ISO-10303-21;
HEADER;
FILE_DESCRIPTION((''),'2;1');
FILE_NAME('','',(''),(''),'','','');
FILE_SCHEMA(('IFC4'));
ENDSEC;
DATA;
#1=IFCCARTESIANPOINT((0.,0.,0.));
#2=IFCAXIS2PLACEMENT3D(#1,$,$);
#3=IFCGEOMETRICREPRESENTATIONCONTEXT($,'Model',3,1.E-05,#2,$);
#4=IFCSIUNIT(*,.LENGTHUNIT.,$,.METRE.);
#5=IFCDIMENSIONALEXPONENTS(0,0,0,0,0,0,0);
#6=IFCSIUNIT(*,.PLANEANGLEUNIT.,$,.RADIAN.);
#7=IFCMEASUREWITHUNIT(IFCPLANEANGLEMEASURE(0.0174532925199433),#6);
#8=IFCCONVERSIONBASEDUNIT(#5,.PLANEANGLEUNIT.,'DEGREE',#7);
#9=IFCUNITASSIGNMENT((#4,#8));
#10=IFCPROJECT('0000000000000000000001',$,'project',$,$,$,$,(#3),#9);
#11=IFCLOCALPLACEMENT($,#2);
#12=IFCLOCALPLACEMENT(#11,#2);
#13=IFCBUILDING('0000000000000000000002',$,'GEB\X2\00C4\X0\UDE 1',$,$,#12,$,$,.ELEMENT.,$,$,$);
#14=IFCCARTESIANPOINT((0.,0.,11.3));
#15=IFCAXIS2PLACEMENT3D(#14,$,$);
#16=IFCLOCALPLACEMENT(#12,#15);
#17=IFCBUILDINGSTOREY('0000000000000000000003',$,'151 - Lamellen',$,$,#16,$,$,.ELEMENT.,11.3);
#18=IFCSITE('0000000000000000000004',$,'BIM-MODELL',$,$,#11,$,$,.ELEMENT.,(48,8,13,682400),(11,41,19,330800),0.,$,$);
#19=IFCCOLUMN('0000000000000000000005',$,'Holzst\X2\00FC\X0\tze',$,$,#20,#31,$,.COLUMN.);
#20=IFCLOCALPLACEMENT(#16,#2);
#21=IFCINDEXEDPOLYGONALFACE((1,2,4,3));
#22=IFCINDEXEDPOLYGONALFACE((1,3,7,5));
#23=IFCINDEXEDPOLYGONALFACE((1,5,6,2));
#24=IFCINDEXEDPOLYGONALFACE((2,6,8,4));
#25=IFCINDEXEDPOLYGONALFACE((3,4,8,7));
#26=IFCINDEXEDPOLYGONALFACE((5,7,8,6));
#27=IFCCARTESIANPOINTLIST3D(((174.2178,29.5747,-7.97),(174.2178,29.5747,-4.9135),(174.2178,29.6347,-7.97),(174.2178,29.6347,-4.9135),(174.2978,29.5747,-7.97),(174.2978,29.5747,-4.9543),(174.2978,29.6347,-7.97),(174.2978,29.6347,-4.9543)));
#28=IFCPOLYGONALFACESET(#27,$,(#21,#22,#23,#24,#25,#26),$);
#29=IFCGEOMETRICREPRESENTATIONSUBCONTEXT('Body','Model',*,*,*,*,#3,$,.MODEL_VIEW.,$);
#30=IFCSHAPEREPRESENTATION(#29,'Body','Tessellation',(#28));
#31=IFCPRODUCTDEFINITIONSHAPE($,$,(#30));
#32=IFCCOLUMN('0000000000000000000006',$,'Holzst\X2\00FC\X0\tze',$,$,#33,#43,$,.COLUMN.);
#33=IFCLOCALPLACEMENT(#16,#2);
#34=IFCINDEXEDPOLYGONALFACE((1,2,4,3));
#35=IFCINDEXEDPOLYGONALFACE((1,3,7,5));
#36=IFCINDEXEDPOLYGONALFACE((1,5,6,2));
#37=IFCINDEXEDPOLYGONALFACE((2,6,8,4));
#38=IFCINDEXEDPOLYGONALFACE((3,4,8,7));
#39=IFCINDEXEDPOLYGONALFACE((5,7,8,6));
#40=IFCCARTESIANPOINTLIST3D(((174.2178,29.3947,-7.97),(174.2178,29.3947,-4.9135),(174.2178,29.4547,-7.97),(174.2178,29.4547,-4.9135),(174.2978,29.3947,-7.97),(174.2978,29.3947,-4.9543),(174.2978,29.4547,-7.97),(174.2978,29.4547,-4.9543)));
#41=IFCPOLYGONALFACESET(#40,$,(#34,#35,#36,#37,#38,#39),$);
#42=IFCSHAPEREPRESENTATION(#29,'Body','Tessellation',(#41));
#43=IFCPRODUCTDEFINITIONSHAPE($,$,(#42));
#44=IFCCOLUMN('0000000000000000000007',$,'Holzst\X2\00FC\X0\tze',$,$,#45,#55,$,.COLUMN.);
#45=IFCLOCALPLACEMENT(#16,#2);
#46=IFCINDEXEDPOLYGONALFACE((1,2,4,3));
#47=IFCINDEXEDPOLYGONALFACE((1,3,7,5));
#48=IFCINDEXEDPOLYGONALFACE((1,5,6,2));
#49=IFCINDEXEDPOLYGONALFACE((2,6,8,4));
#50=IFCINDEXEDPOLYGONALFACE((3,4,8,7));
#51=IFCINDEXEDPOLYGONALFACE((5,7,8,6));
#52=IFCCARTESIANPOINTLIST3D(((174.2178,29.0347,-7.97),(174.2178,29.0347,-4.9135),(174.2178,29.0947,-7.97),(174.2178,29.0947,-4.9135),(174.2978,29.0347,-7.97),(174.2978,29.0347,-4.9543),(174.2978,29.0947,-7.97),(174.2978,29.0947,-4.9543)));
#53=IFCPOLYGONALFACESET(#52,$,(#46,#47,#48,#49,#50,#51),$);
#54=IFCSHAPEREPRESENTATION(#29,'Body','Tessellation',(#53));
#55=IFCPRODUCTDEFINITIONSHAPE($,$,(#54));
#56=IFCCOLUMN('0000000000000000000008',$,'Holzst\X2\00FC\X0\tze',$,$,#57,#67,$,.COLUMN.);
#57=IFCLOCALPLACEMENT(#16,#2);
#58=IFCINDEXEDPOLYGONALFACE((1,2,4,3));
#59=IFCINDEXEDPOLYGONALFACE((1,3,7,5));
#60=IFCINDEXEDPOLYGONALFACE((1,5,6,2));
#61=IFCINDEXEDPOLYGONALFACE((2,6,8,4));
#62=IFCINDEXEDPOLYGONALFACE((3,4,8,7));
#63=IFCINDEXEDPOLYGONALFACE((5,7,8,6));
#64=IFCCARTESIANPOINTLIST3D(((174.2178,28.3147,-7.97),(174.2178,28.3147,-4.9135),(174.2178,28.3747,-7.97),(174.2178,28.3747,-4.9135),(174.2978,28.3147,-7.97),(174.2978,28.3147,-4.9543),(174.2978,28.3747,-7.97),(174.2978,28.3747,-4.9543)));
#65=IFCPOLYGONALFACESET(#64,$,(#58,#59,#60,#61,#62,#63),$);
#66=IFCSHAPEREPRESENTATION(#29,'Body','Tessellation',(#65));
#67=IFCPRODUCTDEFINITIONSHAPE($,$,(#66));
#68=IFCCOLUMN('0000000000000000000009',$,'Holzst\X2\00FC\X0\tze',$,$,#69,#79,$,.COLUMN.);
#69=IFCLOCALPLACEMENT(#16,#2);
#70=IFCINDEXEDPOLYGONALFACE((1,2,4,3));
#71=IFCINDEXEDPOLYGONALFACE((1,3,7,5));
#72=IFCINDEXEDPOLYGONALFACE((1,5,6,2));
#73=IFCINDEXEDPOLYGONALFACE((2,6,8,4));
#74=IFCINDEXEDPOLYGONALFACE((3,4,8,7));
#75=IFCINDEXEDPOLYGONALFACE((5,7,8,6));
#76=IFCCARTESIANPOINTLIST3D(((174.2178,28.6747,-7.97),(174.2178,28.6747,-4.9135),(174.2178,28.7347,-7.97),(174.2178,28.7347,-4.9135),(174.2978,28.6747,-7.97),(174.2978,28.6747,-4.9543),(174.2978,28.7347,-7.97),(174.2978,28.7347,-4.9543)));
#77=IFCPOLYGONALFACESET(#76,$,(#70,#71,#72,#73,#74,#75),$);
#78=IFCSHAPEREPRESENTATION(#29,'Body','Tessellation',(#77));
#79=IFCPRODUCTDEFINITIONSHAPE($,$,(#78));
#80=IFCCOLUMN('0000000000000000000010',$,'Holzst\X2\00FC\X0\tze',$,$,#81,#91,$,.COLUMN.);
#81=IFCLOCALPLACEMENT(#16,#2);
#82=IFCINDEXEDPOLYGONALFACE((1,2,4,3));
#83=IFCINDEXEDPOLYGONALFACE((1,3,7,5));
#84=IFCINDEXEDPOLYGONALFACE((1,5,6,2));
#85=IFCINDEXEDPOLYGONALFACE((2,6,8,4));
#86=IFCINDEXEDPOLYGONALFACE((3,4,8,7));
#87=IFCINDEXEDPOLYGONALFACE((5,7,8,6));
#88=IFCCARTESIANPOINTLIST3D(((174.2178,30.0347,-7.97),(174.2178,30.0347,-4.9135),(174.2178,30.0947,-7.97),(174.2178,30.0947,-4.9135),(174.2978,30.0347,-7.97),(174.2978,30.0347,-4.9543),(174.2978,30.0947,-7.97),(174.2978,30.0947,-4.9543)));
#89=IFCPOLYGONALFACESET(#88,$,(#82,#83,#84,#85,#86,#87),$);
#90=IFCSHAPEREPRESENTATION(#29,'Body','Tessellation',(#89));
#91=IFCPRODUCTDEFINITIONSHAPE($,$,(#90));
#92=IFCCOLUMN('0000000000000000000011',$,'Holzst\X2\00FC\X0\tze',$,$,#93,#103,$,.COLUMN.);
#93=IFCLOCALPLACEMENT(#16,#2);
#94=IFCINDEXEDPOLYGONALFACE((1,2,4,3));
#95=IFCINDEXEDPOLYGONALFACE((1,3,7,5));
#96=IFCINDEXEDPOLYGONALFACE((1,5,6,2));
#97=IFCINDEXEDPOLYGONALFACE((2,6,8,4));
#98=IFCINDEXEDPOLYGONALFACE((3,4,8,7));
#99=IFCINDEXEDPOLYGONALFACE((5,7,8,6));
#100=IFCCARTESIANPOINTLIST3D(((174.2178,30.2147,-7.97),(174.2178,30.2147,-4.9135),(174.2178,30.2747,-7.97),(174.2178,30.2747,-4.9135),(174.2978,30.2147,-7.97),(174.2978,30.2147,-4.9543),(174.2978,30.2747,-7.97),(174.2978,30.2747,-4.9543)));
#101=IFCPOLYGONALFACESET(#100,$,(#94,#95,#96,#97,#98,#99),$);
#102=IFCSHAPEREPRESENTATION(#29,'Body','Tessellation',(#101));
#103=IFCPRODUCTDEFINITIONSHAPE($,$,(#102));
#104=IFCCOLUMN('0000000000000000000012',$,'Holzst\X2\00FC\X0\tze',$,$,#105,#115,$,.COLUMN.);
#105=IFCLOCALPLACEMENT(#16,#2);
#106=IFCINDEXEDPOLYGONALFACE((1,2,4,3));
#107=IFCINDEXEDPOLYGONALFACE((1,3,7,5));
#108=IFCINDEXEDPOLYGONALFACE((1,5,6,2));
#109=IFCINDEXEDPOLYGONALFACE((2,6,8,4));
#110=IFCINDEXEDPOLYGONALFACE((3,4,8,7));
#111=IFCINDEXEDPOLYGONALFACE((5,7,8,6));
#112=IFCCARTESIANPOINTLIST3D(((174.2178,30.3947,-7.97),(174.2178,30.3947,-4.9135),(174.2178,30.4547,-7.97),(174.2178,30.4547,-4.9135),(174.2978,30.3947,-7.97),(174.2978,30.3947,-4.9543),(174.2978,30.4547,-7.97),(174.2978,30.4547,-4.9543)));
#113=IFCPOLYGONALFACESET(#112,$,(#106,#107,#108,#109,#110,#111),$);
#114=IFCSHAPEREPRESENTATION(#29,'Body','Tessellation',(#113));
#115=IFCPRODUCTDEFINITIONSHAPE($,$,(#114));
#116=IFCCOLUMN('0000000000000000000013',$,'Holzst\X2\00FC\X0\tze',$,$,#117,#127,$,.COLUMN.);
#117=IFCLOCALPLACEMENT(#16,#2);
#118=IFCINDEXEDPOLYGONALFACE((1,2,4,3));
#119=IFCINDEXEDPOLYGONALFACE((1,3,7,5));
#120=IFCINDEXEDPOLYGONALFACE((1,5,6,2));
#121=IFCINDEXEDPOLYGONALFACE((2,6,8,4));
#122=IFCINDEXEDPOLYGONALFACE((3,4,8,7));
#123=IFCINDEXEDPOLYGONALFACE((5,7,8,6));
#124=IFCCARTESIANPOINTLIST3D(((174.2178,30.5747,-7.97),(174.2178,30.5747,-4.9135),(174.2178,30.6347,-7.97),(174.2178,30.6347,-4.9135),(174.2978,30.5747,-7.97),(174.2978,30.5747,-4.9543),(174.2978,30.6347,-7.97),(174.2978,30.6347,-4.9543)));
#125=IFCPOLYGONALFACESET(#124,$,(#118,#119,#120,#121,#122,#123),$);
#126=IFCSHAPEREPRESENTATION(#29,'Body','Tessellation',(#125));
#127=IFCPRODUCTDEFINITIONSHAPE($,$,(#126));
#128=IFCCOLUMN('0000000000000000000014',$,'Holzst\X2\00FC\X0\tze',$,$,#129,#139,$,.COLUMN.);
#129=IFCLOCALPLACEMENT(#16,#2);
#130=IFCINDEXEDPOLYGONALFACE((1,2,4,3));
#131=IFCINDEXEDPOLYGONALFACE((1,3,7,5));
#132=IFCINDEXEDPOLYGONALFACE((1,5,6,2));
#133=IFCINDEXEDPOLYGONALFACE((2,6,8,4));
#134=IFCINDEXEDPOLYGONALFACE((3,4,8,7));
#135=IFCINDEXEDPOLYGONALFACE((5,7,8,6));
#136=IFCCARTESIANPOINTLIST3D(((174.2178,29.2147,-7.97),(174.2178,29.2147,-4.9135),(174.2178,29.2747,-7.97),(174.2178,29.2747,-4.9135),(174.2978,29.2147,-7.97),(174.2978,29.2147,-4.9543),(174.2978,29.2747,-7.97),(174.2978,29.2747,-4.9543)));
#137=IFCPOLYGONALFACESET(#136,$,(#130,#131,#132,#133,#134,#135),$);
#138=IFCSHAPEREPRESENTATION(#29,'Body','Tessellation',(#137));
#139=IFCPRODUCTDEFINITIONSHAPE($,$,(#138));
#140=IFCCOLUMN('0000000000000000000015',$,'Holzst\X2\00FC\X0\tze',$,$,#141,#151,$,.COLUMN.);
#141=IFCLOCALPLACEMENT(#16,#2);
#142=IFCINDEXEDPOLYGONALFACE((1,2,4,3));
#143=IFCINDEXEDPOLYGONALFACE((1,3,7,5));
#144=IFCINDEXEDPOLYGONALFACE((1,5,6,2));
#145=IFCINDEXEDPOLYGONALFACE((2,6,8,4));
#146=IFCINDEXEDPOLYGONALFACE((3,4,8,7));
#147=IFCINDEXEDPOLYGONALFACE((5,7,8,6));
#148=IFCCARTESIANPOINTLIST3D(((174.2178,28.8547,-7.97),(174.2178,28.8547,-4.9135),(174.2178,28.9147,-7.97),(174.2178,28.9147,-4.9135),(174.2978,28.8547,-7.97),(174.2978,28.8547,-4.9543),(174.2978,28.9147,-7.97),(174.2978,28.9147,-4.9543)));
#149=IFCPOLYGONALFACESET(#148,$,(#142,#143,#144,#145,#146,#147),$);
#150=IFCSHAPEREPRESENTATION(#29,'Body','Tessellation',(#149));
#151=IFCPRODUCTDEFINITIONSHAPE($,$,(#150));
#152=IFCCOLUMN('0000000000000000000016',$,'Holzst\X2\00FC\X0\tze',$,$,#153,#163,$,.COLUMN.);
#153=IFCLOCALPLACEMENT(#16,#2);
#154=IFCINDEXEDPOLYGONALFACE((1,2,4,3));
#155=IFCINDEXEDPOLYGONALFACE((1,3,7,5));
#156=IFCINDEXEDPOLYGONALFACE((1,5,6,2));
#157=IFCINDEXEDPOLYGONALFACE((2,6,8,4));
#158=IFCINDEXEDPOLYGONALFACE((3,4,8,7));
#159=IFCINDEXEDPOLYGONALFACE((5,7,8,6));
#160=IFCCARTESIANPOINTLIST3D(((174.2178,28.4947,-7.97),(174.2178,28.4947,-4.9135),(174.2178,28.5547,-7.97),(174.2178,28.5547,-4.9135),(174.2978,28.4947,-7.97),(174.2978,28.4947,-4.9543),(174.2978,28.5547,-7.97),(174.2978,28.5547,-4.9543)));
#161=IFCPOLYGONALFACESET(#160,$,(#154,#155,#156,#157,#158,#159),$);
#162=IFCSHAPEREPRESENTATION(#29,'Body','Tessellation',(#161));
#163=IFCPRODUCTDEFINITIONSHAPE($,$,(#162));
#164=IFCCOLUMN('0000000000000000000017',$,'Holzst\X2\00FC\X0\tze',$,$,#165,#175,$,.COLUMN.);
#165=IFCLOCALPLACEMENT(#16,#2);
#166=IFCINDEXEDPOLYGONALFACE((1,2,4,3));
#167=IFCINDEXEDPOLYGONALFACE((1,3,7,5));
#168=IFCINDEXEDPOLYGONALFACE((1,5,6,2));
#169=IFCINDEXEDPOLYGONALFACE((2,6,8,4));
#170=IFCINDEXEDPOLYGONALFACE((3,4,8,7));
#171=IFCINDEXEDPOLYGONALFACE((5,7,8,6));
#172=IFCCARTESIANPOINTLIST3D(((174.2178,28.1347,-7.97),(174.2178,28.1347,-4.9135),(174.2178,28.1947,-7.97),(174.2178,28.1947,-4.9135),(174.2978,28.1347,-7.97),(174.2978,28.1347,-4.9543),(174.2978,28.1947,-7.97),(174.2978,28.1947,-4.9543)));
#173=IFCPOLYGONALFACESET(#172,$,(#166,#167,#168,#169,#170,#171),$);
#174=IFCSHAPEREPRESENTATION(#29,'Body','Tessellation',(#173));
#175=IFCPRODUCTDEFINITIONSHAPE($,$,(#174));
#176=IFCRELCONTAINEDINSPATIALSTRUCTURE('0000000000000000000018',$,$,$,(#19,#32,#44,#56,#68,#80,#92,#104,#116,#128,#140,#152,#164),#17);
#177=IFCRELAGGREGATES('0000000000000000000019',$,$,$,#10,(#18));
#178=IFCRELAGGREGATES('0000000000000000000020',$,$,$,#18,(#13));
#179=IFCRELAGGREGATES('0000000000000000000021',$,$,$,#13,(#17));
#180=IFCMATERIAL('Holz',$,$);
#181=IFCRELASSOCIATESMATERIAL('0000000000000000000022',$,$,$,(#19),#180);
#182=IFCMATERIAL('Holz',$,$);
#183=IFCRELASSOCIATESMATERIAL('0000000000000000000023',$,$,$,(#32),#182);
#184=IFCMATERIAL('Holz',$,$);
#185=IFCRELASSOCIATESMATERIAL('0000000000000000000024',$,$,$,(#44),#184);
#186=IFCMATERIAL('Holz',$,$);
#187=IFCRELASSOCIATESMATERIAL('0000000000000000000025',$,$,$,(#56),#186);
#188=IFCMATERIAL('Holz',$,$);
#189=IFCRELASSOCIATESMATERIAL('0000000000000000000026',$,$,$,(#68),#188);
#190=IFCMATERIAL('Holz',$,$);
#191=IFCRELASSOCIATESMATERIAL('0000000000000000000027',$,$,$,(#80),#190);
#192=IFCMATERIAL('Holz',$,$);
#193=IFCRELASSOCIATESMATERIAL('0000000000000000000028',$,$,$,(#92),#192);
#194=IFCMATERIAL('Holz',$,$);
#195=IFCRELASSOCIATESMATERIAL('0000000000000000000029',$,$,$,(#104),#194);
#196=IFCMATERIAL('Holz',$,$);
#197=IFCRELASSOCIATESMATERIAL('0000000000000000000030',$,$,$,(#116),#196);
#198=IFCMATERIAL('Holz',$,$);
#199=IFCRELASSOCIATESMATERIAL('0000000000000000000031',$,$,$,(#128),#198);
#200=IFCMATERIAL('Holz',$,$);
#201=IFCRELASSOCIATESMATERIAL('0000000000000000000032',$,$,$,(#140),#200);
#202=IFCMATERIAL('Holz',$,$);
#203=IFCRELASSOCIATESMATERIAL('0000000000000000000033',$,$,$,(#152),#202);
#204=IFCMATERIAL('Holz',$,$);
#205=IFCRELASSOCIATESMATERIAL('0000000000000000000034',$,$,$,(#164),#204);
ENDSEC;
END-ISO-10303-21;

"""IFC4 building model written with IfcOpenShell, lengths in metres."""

from ifc_helpers import new_model, entity, si_unit, converted_unit, frame, frame_2d, origin, origin_with_axes, place, context, subcontext, project, spatial, rectangle, extrude, clip, halfspace, material, element, save


model = new_model("IFC4")

# Units and contexts
model_context = context("Model", 3, precision=1e-05, world=origin())
body_context = subcontext(model_context, "Body", "Model", "MODEL_VIEW")
ifc_project = project(units=[si_unit("LENGTHUNIT", "METRE"), converted_unit("PLANEANGLEUNIT", "DEGREE", entity("IfcPlaneAngleMeasure", 0.0174532925199433), si_unit("PLANEANGLEUNIT", "RADIAN"), dimensions=[0, 0, 0, 0, 0, 0, 0])], contexts=[model_context])

# Site, building, storey
site_placement = place(None, origin())
site = spatial("IfcSite", under=ifc_project, at=site_placement, Name="BIM-MODELL", CompositionType="ELEMENT", RefLatitude=(48, 8, 13, 682400), RefLongitude=(11, 41, 19, 330800), RefElevation=0.0)
building_placement = place(site_placement, origin())
building = spatial("IfcBuilding", under=site, at=building_placement, Name="GEBÄUDE 1", CompositionType="ELEMENT")
storey_placement = place(building_placement, frame((0.0, 0.0, 11.3)))
storey = spatial("IfcBuildingStorey", under=building, at=storey_placement, Name="151 - Lamellen", CompositionType="ELEMENT", Elevation=11.3)

# Columns
ifc_material_1 = material(Name="Holz")
column_1_placement = place(storey_placement, frame((174.2978, 29.5747, -7.97)))
element("IfcColumn", 1, at=column_1_placement, inside=storey, material=ifc_material_1, Name="Holzstütze", PredefinedType="COLUMN", context=body_context, shape_type="Clipping", body=[
    clip(extrude(rectangle(XDim=0.06, YDim=0.08, at=frame_2d((-0.04, 0.03), x_axis=(0.0, 1.0))), origin_with_axes(), (0.0, 0.0, 1.0), 3.0565), halfspace(frame((-0.04, 0.03, 3.0361), z_axis=(-0.45399, 0.0, -0.891007), x_axis=(0.891007, 0.0, -0.45399)), True)),
])
ifc_material_2 = material(Name="Holz")
column_2_placement = place(storey_placement, frame((174.2978, 29.3947, -7.97)))
element("IfcColumn", 2, at=column_2_placement, inside=storey, material=ifc_material_2, Name="Holzstütze", PredefinedType="COLUMN", context=body_context, shape_type="Clipping", body=[
    clip(extrude(rectangle(XDim=0.06, YDim=0.08, at=frame_2d((-0.04, 0.03), x_axis=(0.0, 1.0))), origin_with_axes(), (0.0, 0.0, 1.0), 3.0565), halfspace(frame((-0.04, 0.03, 3.0361), z_axis=(-0.45399, 0.0, -0.891007), x_axis=(0.891007, 0.0, -0.45399)), True)),
])
ifc_material_3 = material(Name="Holz")
column_3_placement = place(storey_placement, frame((174.2978, 29.0347, -7.97)))
element("IfcColumn", 3, at=column_3_placement, inside=storey, material=ifc_material_3, Name="Holzstütze", PredefinedType="COLUMN", context=body_context, shape_type="Clipping", body=[
    clip(extrude(rectangle(XDim=0.06, YDim=0.08, at=frame_2d((-0.04, 0.03), x_axis=(0.0, 1.0))), origin_with_axes(), (0.0, 0.0, 1.0), 3.0565), halfspace(frame((-0.04, 0.03, 3.0361), z_axis=(-0.45399, 0.0, -0.891007), x_axis=(0.891007, 0.0, -0.45399)), True)),
])
ifc_material_4 = material(Name="Holz")
column_4_placement = place(storey_placement, frame((174.2978, 28.3147, -7.97)))
element("IfcColumn", 4, at=column_4_placement, inside=storey, material=ifc_material_4, Name="Holzstütze", PredefinedType="COLUMN", context=body_context, shape_type="Clipping", body=[
    clip(extrude(rectangle(XDim=0.06, YDim=0.08, at=frame_2d((-0.04, 0.03), x_axis=(0.0, 1.0))), origin_with_axes(), (0.0, 0.0, 1.0), 3.0565), halfspace(frame((-0.04, 0.03, 3.0361), z_axis=(-0.45399, 0.0, -0.891007), x_axis=(0.891007, 0.0, -0.45399)), True)),
])
ifc_material_5 = material(Name="Holz")
column_5_placement = place(storey_placement, frame((174.2978, 28.6747, -7.97)))
element("IfcColumn", 5, at=column_5_placement, inside=storey, material=ifc_material_5, Name="Holzstütze", PredefinedType="COLUMN", context=body_context, shape_type="Clipping", body=[
    clip(extrude(rectangle(XDim=0.06, YDim=0.08, at=frame_2d((-0.04, 0.03), x_axis=(0.0, 1.0))), origin_with_axes(), (0.0, 0.0, 1.0), 3.0565), halfspace(frame((-0.04, 0.03, 3.0361), z_axis=(-0.45399, 0.0, -0.891007), x_axis=(0.891007, 0.0, -0.45399)), True)),
])
ifc_material_6 = material(Name="Holz")
column_6_placement = place(storey_placement, frame((174.2978, 30.0347, -7.97)))
element("IfcColumn", 6, at=column_6_placement, inside=storey, material=ifc_material_6, Name="Holzstütze", PredefinedType="COLUMN", context=body_context, shape_type="Clipping", body=[
    clip(extrude(rectangle(XDim=0.06, YDim=0.08, at=frame_2d((-0.04, 0.03), x_axis=(0.0, 1.0))), origin_with_axes(), (0.0, 0.0, 1.0), 3.0565), halfspace(frame((-0.04, 0.03, 3.0361), z_axis=(-0.45399, 0.0, -0.891007), x_axis=(0.891007, 0.0, -0.45399)), True)),
])
ifc_material_7 = material(Name="Holz")
column_7_placement = place(storey_placement, frame((174.2978, 30.2147, -7.97)))
element("IfcColumn", 7, at=column_7_placement, inside=storey, material=ifc_material_7, Name="Holzstütze", PredefinedType="COLUMN", context=body_context, shape_type="Clipping", body=[
    clip(extrude(rectangle(XDim=0.06, YDim=0.08, at=frame_2d((-0.04, 0.03), x_axis=(0.0, 1.0))), origin_with_axes(), (0.0, 0.0, 1.0), 3.0565), halfspace(frame((-0.04, 0.03, 3.0361), z_axis=(-0.45399, 0.0, -0.891007), x_axis=(0.891007, 0.0, -0.45399)), True)),
])
ifc_material_8 = material(Name="Holz")
column_8_placement = place(storey_placement, frame((174.2978, 30.3947, -7.97)))
element("IfcColumn", 8, at=column_8_placement, inside=storey, material=ifc_material_8, Name="Holzstütze", PredefinedType="COLUMN", context=body_context, shape_type="Clipping", body=[
    clip(extrude(rectangle(XDim=0.06, YDim=0.08, at=frame_2d((-0.04, 0.03), x_axis=(0.0, 1.0))), origin_with_axes(), (0.0, 0.0, 1.0), 3.0565), halfspace(frame((-0.04, 0.03, 3.0361), z_axis=(-0.45399, 0.0, -0.891007), x_axis=(0.891007, 0.0, -0.45399)), True)),
])
ifc_material_9 = material(Name="Holz")
column_9_placement = place(storey_placement, frame((174.2978, 30.5747, -7.97)))
element("IfcColumn", 9, at=column_9_placement, inside=storey, material=ifc_material_9, Name="Holzstütze", PredefinedType="COLUMN", context=body_context, shape_type="Clipping", body=[
    clip(extrude(rectangle(XDim=0.06, YDim=0.08, at=frame_2d((-0.04, 0.03), x_axis=(0.0, 1.0))), origin_with_axes(), (0.0, 0.0, 1.0), 3.0565), halfspace(frame((-0.04, 0.03, 3.0361), z_axis=(-0.45399, 0.0, -0.891007), x_axis=(0.891007, 0.0, -0.45399)), True)),
])
ifc_material_10 = material(Name="Holz")
column_10_placement = place(storey_placement, frame((174.2978, 29.2147, -7.97)))
element("IfcColumn", 10, at=column_10_placement, inside=storey, material=ifc_material_10, Name="Holzstütze", PredefinedType="COLUMN", context=body_context, shape_type="Clipping", body=[
    clip(extrude(rectangle(XDim=0.06, YDim=0.08, at=frame_2d((-0.04, 0.03), x_axis=(0.0, 1.0))), origin_with_axes(), (0.0, 0.0, 1.0), 3.0565), halfspace(frame((-0.04, 0.03, 3.0361), z_axis=(-0.45399, 0.0, -0.891007), x_axis=(0.891007, 0.0, -0.45399)), True)),
])
ifc_material_11 = material(Name="Holz")
column_11_placement = place(storey_placement, frame((174.2978, 28.8547, -7.97)))
element("IfcColumn", 11, at=column_11_placement, inside=storey, material=ifc_material_11, Name="Holzstütze", PredefinedType="COLUMN", context=body_context, shape_type="Clipping", body=[
    clip(extrude(rectangle(XDim=0.06, YDim=0.08, at=frame_2d((-0.04, 0.03), x_axis=(0.0, 1.0))), origin_with_axes(), (0.0, 0.0, 1.0), 3.0565), halfspace(frame((-0.04, 0.03, 3.0361), z_axis=(-0.45399, 0.0, -0.891007), x_axis=(0.891007, 0.0, -0.45399)), True)),
])
ifc_material_12 = material(Name="Holz")
column_12_placement = place(storey_placement, frame((174.2978, 28.4947, -7.97)))
element("IfcColumn", 12, at=column_12_placement, inside=storey, material=ifc_material_12, Name="Holzstütze", PredefinedType="COLUMN", context=body_context, shape_type="Clipping", body=[
    clip(extrude(rectangle(XDim=0.06, YDim=0.08, at=frame_2d((-0.04, 0.03), x_axis=(0.0, 1.0))), origin_with_axes(), (0.0, 0.0, 1.0), 3.0565), halfspace(frame((-0.04, 0.03, 3.0361), z_axis=(-0.45399, 0.0, -0.891007), x_axis=(0.891007, 0.0, -0.45399)), True)),
])
ifc_material_13 = material(Name="Holz")
column_13_placement = place(storey_placement, frame((174.2978, 28.1347, -7.97)))
element("IfcColumn", 13, at=column_13_placement, inside=storey, material=ifc_material_13, Name="Holzstütze", PredefinedType="COLUMN", context=body_context, shape_type="Clipping", body=[
    clip(extrude(rectangle(XDim=0.06, YDim=0.08, at=frame_2d((-0.04, 0.03), x_axis=(0.0, 1.0))), origin_with_axes(), (0.0, 0.0, 1.0), 3.0565), halfspace(frame((-0.04, 0.03, 3.0361), z_axis=(-0.45399, 0.0, -0.891007), x_axis=(0.891007, 0.0, -0.45399)), True)),
])

save(model, "model.ifc")
